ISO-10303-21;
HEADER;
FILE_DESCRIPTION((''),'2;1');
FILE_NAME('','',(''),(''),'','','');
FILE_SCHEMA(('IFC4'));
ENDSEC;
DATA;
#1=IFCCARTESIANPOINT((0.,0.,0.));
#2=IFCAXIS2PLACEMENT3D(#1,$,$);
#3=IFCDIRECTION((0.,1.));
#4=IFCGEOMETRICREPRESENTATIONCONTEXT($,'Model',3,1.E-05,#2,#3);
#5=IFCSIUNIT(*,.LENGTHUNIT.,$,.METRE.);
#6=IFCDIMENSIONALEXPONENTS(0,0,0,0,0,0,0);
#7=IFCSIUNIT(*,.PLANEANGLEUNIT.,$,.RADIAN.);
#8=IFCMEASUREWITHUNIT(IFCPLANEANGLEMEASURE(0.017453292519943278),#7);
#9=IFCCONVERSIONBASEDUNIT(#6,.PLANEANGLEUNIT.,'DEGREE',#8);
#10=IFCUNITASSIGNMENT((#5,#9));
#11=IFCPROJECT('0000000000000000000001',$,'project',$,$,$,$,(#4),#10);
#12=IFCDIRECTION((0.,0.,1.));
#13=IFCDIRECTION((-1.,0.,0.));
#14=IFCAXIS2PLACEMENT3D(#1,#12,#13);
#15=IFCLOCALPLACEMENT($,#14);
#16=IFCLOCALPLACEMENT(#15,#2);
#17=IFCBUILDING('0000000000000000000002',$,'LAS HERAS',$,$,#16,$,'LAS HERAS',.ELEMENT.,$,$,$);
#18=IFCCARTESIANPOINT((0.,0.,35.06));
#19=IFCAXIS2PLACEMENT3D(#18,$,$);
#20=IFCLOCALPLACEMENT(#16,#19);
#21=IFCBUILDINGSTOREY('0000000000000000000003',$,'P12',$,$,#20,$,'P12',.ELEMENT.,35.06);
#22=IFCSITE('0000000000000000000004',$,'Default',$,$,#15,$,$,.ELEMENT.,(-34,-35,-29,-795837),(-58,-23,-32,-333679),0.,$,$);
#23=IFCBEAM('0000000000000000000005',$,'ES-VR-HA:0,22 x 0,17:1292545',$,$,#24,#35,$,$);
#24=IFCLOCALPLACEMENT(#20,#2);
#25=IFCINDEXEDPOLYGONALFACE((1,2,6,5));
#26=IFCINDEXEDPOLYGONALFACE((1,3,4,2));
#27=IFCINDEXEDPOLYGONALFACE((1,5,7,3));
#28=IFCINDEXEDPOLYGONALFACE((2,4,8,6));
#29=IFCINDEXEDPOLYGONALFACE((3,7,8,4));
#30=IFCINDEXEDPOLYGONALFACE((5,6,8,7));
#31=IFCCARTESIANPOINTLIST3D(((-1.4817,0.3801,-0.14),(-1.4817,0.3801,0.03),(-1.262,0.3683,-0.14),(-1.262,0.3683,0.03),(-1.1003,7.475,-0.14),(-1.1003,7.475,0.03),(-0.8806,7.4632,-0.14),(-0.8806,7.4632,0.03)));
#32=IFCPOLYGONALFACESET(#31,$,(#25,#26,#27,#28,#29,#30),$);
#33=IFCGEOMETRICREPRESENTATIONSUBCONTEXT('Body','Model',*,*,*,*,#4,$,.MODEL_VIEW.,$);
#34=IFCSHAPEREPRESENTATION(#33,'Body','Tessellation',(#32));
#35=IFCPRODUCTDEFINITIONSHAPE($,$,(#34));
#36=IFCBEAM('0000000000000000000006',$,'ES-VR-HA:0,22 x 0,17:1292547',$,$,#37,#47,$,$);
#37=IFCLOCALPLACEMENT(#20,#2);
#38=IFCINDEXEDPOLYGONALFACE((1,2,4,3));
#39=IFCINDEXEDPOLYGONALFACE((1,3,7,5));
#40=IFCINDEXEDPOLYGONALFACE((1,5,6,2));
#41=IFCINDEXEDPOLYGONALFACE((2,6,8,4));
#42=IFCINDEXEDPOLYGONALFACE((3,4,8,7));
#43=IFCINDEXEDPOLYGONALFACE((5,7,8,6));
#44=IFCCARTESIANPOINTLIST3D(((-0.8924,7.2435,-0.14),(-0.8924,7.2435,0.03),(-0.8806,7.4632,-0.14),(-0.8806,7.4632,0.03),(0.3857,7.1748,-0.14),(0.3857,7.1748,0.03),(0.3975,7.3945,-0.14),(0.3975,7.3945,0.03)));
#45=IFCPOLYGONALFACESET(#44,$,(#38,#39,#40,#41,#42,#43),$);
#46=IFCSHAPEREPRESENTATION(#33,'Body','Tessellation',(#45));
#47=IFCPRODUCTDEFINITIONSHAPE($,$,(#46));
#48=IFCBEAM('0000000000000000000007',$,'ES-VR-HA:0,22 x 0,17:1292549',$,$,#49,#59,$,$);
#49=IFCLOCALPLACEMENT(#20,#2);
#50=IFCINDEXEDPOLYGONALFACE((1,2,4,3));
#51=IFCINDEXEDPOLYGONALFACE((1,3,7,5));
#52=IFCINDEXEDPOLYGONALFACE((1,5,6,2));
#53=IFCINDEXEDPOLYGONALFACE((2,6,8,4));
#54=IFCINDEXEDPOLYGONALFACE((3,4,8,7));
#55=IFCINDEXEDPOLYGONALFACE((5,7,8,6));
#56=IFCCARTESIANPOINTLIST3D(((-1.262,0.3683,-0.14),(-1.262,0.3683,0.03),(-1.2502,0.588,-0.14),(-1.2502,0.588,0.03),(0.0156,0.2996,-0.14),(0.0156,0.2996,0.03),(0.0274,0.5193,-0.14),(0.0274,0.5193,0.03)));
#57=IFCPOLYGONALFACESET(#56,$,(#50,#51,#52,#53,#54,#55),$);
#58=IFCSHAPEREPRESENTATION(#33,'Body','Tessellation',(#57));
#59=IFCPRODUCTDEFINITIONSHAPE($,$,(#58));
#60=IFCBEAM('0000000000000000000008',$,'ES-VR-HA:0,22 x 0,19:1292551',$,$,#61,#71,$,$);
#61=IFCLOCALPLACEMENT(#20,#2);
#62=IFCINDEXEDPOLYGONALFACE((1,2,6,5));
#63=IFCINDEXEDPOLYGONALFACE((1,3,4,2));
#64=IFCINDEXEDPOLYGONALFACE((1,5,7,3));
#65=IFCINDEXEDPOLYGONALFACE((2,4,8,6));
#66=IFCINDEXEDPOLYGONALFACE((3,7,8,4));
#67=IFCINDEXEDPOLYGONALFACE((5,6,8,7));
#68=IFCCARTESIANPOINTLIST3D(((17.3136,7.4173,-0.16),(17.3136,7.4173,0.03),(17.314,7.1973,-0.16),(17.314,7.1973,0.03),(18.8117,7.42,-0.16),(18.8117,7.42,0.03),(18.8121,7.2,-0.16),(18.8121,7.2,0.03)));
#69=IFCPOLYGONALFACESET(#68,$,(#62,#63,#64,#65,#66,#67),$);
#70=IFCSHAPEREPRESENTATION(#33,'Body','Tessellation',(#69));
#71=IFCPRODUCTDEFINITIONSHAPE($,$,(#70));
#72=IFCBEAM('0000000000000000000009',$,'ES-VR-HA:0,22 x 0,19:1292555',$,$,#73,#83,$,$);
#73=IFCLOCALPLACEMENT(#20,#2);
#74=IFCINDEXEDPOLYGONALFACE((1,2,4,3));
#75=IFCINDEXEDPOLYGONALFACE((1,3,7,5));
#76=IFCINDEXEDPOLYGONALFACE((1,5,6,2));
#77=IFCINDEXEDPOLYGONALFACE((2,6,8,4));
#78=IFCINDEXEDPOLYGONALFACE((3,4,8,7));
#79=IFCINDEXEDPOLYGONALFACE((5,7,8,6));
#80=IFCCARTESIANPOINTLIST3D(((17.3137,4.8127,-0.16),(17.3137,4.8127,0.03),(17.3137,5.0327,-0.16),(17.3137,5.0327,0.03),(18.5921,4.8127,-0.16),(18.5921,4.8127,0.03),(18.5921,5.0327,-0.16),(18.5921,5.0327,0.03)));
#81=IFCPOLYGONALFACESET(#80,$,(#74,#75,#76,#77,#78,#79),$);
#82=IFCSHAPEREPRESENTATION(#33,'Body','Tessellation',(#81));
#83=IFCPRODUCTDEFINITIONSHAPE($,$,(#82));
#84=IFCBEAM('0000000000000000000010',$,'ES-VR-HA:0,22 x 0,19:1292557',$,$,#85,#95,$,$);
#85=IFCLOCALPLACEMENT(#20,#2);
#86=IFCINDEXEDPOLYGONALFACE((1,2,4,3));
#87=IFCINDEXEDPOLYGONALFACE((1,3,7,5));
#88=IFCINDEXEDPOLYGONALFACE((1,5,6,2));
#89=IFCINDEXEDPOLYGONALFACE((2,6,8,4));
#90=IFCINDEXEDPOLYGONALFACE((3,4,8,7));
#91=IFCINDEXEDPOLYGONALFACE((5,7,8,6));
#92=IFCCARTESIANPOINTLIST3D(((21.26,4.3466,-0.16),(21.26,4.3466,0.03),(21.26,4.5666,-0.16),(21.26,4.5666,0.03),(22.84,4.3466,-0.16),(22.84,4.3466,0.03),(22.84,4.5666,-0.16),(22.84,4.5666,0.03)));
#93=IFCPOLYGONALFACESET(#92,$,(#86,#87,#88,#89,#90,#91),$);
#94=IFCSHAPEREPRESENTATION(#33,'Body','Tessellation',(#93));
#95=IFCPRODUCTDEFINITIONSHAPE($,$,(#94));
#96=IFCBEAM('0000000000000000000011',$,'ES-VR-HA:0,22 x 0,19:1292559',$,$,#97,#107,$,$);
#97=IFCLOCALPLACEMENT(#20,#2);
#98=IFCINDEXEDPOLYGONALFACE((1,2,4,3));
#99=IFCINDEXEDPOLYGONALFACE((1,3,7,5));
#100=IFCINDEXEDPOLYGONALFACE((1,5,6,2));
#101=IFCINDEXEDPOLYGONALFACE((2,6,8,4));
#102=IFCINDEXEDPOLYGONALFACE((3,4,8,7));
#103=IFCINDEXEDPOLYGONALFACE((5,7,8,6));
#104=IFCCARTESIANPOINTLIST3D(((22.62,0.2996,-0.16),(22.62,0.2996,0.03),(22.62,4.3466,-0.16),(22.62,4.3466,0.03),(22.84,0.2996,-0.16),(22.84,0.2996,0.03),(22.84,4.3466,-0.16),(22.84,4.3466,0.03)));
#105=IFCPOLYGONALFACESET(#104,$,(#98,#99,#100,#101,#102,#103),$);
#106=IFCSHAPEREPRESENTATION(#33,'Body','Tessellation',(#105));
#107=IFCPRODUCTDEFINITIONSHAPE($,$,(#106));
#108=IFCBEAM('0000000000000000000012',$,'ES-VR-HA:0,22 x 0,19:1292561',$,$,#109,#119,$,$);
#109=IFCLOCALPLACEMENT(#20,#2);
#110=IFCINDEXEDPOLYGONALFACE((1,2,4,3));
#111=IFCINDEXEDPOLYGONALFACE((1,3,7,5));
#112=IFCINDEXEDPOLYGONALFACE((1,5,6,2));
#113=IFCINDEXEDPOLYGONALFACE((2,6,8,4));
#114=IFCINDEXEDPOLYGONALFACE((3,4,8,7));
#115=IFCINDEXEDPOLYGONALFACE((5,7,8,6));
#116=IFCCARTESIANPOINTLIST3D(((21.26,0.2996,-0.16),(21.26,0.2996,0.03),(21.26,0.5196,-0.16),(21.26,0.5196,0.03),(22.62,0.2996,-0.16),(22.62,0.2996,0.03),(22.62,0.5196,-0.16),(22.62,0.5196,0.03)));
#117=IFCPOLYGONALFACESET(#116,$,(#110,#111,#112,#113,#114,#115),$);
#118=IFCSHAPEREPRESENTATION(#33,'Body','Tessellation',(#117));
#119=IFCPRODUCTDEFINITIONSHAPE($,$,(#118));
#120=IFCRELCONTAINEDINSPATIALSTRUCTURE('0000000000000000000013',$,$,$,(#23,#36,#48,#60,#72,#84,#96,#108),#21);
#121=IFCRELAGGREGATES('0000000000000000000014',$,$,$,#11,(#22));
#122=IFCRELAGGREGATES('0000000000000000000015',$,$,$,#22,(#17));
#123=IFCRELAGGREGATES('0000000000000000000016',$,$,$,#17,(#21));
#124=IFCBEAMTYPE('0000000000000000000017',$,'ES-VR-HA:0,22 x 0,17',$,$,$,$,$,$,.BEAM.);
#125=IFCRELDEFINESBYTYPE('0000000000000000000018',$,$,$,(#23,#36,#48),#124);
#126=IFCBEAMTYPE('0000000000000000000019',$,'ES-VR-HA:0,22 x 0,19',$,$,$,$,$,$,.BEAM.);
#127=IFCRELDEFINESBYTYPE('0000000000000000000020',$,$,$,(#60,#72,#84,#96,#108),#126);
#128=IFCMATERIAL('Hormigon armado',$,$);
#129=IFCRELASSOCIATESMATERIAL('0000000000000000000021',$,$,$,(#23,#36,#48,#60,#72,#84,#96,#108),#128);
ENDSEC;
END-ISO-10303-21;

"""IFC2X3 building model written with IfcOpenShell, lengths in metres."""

from ifc_helpers import new_model, entity, si_unit, converted_unit, direction, frame, frame_2d, origin, origin_2d_with_axis, place, context, subcontext, project, spatial, rectangle, extrude, material, type_object, element, save


model = new_model("IFC2X3")

# Units and contexts
model_context = context("Model", 3, precision=1e-05, world=origin(), true_north=direction((0.0, 1.0)))
body_context = subcontext(model_context, "Body", "Model", "MODEL_VIEW")
ifc_project = project(units=[si_unit("LENGTHUNIT", "METRE"), converted_unit("PLANEANGLEUNIT", "DEGREE", entity("IfcPlaneAngleMeasure", 0.017453292519943278), si_unit("PLANEANGLEUNIT", "RADIAN"), dimensions=[0, 0, 0, 0, 0, 0, 0])], contexts=[model_context])

# Site, building, storey
site_placement = place(None, frame((0.0, 0.0, 0.0), z_axis=(0.0, 0.0, 1.0), x_axis=(-1.0, 0.0, 0.0)))
site = spatial("IfcSite", under=ifc_project, at=site_placement, Name="Default", CompositionType="ELEMENT", RefLatitude=(-34, -35, -29, -795837), RefLongitude=(-58, -23, -32, -333679), RefElevation=0.0)
building_placement = place(site_placement, origin())
building = spatial("IfcBuilding", under=site, at=building_placement, Name="LAS HERAS", LongName="LAS HERAS", CompositionType="ELEMENT")
storey_placement = place(building_placement, frame((0.0, 0.0, 35.06)))
storey = spatial("IfcBuildingStorey", under=building, at=storey_placement, Name="P12", LongName="P12", CompositionType="ELEMENT", Elevation=35.06)

# Beams
ifc_material = material(Name="Hormigon armado")
beam_type_1 = type_object("IfcBeamType", Name="ES-VR-HA:0,22 x 0,17", PredefinedType="BEAM")
beam_1_placement = place(storey_placement, frame((-0.9963, 7.3593, 0.03), z_axis=(0.0, 0.0, 1.0), x_axis=(-0.05369, -0.998558, 0.0)))
element("IfcBeam", 1, at=beam_1_placement, inside=storey, type_object=beam_type_1, material=ifc_material, Name="ES-VR-HA:0,22 x 0,17:1292545", context=body_context, shape_type="SweptSolid", body=[
    extrude(rectangle(XDim=0.17, YDim=0.22, at=frame_2d((0.0, 0.0), x_axis=(1.0, 0.0))), frame((-0.11, 0.0, -0.085), z_axis=(1.0, 0.0, 0.0), x_axis=(0.0, 0.0, -1.0)), (0.0, 0.0, 1.0), 7.1052),
])
beam_2_placement = place(storey_placement, frame((0.3916, 7.2846, 0.03), z_axis=(0.0, 0.0, 1.0), x_axis=(-0.998558, 0.05368, 0.0)))
element("IfcBeam", 2, at=beam_2_placement, inside=storey, type_object=beam_type_1, material=ifc_material, Name="ES-VR-HA:0,22 x 0,17:1292547", context=body_context, shape_type="SweptSolid", body=[
    extrude(rectangle(XDim=0.17, YDim=0.22, at=frame_2d((0.0, 0.0), x_axis=(1.0, 0.0))), frame((0.0, 0.0, -0.085), z_axis=(1.0, 0.0, 0.0), x_axis=(0.0, 0.0, -1.0)), (0.0, 0.0, 1.0), 1.28),
])
beam_3_placement = place(storey_placement, frame((0.0215, 0.4094, 0.03), z_axis=(0.0, 0.0, 1.0), x_axis=(-0.998558, 0.05369, 0.0)))
element("IfcBeam", 3, at=beam_3_placement, inside=storey, type_object=beam_type_1, material=ifc_material, Name="ES-VR-HA:0,22 x 0,17:1292549", context=body_context, shape_type="SweptSolid", body=[
    extrude(rectangle(XDim=0.17, YDim=0.22, at=frame_2d((0.0, 0.0), x_axis=(1.0, 0.0))), frame((0.0, 0.0, -0.085), z_axis=(1.0, 0.0, 0.0), x_axis=(0.0, 0.0, -1.0)), (0.0, 0.0, 1.0), 1.2795),
])
beam_type_2 = type_object("IfcBeamType", Name="ES-VR-HA:0,22 x 0,19", PredefinedType="BEAM")
beam_4_placement = place(storey_placement, frame((17.3138, 7.3073, 0.03), z_axis=(0.0, 0.0, 1.0), x_axis=(0.999998, 0.001781, 0.0)))
element("IfcBeam", 4, at=beam_4_placement, inside=storey, type_object=beam_type_2, material=ifc_material, Name="ES-VR-HA:0,22 x 0,19:1292551", context=body_context, shape_type="SweptSolid", body=[
    extrude(rectangle(XDim=0.19, YDim=0.22, at=frame_2d((0.0, 0.0), x_axis=(1.0, 0.0))), frame((0.0, 0.0, -0.095), z_axis=(1.0, 0.0, 0.0), x_axis=(0.0, 0.0, -1.0)), (0.0, 0.0, 1.0), 1.4981),
])
beam_5_placement = place(storey_placement, frame((17.3137, 4.9227, 0.03)))
element("IfcBeam", 5, at=beam_5_placement, inside=storey, type_object=beam_type_2, material=ifc_material, Name="ES-VR-HA:0,22 x 0,19:1292555", context=body_context, shape_type="SweptSolid", body=[
    extrude(rectangle(XDim=0.19, YDim=0.22, at=frame_2d((0.0, 0.0), x_axis=(1.0, 0.0))), frame((0.0, 0.0, -0.095), z_axis=(1.0, 0.0, 0.0), x_axis=(0.0, 0.0, -1.0)), (0.0, 0.0, 1.0), 1.2784),
])
beam_6_placement = place(storey_placement, frame((21.26, 4.4566, 0.03)))
element("IfcBeam", 6, at=beam_6_placement, inside=storey, type_object=beam_type_2, material=ifc_material, Name="ES-VR-HA:0,22 x 0,19:1292557", context=body_context, shape_type="SweptSolid", body=[
    extrude(rectangle(XDim=0.19, YDim=0.22, at=origin_2d_with_axis()), frame((0.0, 0.0, -0.095), z_axis=(1.0, 0.0, 0.0), x_axis=(0.0, 0.0, -1.0)), (0.0, 0.0, 1.0), 1.58),
])
beam_7_placement = place(storey_placement, frame((22.73, 4.4566, 0.03), z_axis=(0.0, 0.0, 1.0), x_axis=(0.0, -1.0, 0.0)))
element("IfcBeam", 7, at=beam_7_placement, inside=storey, type_object=beam_type_2, material=ifc_material, Name="ES-VR-HA:0,22 x 0,19:1292559", context=body_context, shape_type="SweptSolid", body=[
    extrude(rectangle(XDim=0.19, YDim=0.22, at=frame_2d((0.0, 0.0), x_axis=(1.0, 0.0))), frame((0.11, 0.0, -0.095), z_axis=(1.0, 0.0, 0.0), x_axis=(0.0, 0.0, -1.0)), (0.0, 0.0, 1.0), 4.0471),
])
beam_8_placement = place(storey_placement, frame((21.26, 0.4096, 0.03)))
element("IfcBeam", 8, at=beam_8_placement, inside=storey, type_object=beam_type_2, material=ifc_material, Name="ES-VR-HA:0,22 x 0,19:1292561", context=body_context, shape_type="SweptSolid", body=[
    extrude(rectangle(XDim=0.19, YDim=0.22, at=frame_2d((0.0, 0.0), x_axis=(1.0, 0.0))), frame((0.0, 0.0, -0.095), z_axis=(1.0, 0.0, 0.0), x_axis=(0.0, 0.0, -1.0)), (0.0, 0.0, 1.0), 1.36),
])

save(model, "model.ifc")
